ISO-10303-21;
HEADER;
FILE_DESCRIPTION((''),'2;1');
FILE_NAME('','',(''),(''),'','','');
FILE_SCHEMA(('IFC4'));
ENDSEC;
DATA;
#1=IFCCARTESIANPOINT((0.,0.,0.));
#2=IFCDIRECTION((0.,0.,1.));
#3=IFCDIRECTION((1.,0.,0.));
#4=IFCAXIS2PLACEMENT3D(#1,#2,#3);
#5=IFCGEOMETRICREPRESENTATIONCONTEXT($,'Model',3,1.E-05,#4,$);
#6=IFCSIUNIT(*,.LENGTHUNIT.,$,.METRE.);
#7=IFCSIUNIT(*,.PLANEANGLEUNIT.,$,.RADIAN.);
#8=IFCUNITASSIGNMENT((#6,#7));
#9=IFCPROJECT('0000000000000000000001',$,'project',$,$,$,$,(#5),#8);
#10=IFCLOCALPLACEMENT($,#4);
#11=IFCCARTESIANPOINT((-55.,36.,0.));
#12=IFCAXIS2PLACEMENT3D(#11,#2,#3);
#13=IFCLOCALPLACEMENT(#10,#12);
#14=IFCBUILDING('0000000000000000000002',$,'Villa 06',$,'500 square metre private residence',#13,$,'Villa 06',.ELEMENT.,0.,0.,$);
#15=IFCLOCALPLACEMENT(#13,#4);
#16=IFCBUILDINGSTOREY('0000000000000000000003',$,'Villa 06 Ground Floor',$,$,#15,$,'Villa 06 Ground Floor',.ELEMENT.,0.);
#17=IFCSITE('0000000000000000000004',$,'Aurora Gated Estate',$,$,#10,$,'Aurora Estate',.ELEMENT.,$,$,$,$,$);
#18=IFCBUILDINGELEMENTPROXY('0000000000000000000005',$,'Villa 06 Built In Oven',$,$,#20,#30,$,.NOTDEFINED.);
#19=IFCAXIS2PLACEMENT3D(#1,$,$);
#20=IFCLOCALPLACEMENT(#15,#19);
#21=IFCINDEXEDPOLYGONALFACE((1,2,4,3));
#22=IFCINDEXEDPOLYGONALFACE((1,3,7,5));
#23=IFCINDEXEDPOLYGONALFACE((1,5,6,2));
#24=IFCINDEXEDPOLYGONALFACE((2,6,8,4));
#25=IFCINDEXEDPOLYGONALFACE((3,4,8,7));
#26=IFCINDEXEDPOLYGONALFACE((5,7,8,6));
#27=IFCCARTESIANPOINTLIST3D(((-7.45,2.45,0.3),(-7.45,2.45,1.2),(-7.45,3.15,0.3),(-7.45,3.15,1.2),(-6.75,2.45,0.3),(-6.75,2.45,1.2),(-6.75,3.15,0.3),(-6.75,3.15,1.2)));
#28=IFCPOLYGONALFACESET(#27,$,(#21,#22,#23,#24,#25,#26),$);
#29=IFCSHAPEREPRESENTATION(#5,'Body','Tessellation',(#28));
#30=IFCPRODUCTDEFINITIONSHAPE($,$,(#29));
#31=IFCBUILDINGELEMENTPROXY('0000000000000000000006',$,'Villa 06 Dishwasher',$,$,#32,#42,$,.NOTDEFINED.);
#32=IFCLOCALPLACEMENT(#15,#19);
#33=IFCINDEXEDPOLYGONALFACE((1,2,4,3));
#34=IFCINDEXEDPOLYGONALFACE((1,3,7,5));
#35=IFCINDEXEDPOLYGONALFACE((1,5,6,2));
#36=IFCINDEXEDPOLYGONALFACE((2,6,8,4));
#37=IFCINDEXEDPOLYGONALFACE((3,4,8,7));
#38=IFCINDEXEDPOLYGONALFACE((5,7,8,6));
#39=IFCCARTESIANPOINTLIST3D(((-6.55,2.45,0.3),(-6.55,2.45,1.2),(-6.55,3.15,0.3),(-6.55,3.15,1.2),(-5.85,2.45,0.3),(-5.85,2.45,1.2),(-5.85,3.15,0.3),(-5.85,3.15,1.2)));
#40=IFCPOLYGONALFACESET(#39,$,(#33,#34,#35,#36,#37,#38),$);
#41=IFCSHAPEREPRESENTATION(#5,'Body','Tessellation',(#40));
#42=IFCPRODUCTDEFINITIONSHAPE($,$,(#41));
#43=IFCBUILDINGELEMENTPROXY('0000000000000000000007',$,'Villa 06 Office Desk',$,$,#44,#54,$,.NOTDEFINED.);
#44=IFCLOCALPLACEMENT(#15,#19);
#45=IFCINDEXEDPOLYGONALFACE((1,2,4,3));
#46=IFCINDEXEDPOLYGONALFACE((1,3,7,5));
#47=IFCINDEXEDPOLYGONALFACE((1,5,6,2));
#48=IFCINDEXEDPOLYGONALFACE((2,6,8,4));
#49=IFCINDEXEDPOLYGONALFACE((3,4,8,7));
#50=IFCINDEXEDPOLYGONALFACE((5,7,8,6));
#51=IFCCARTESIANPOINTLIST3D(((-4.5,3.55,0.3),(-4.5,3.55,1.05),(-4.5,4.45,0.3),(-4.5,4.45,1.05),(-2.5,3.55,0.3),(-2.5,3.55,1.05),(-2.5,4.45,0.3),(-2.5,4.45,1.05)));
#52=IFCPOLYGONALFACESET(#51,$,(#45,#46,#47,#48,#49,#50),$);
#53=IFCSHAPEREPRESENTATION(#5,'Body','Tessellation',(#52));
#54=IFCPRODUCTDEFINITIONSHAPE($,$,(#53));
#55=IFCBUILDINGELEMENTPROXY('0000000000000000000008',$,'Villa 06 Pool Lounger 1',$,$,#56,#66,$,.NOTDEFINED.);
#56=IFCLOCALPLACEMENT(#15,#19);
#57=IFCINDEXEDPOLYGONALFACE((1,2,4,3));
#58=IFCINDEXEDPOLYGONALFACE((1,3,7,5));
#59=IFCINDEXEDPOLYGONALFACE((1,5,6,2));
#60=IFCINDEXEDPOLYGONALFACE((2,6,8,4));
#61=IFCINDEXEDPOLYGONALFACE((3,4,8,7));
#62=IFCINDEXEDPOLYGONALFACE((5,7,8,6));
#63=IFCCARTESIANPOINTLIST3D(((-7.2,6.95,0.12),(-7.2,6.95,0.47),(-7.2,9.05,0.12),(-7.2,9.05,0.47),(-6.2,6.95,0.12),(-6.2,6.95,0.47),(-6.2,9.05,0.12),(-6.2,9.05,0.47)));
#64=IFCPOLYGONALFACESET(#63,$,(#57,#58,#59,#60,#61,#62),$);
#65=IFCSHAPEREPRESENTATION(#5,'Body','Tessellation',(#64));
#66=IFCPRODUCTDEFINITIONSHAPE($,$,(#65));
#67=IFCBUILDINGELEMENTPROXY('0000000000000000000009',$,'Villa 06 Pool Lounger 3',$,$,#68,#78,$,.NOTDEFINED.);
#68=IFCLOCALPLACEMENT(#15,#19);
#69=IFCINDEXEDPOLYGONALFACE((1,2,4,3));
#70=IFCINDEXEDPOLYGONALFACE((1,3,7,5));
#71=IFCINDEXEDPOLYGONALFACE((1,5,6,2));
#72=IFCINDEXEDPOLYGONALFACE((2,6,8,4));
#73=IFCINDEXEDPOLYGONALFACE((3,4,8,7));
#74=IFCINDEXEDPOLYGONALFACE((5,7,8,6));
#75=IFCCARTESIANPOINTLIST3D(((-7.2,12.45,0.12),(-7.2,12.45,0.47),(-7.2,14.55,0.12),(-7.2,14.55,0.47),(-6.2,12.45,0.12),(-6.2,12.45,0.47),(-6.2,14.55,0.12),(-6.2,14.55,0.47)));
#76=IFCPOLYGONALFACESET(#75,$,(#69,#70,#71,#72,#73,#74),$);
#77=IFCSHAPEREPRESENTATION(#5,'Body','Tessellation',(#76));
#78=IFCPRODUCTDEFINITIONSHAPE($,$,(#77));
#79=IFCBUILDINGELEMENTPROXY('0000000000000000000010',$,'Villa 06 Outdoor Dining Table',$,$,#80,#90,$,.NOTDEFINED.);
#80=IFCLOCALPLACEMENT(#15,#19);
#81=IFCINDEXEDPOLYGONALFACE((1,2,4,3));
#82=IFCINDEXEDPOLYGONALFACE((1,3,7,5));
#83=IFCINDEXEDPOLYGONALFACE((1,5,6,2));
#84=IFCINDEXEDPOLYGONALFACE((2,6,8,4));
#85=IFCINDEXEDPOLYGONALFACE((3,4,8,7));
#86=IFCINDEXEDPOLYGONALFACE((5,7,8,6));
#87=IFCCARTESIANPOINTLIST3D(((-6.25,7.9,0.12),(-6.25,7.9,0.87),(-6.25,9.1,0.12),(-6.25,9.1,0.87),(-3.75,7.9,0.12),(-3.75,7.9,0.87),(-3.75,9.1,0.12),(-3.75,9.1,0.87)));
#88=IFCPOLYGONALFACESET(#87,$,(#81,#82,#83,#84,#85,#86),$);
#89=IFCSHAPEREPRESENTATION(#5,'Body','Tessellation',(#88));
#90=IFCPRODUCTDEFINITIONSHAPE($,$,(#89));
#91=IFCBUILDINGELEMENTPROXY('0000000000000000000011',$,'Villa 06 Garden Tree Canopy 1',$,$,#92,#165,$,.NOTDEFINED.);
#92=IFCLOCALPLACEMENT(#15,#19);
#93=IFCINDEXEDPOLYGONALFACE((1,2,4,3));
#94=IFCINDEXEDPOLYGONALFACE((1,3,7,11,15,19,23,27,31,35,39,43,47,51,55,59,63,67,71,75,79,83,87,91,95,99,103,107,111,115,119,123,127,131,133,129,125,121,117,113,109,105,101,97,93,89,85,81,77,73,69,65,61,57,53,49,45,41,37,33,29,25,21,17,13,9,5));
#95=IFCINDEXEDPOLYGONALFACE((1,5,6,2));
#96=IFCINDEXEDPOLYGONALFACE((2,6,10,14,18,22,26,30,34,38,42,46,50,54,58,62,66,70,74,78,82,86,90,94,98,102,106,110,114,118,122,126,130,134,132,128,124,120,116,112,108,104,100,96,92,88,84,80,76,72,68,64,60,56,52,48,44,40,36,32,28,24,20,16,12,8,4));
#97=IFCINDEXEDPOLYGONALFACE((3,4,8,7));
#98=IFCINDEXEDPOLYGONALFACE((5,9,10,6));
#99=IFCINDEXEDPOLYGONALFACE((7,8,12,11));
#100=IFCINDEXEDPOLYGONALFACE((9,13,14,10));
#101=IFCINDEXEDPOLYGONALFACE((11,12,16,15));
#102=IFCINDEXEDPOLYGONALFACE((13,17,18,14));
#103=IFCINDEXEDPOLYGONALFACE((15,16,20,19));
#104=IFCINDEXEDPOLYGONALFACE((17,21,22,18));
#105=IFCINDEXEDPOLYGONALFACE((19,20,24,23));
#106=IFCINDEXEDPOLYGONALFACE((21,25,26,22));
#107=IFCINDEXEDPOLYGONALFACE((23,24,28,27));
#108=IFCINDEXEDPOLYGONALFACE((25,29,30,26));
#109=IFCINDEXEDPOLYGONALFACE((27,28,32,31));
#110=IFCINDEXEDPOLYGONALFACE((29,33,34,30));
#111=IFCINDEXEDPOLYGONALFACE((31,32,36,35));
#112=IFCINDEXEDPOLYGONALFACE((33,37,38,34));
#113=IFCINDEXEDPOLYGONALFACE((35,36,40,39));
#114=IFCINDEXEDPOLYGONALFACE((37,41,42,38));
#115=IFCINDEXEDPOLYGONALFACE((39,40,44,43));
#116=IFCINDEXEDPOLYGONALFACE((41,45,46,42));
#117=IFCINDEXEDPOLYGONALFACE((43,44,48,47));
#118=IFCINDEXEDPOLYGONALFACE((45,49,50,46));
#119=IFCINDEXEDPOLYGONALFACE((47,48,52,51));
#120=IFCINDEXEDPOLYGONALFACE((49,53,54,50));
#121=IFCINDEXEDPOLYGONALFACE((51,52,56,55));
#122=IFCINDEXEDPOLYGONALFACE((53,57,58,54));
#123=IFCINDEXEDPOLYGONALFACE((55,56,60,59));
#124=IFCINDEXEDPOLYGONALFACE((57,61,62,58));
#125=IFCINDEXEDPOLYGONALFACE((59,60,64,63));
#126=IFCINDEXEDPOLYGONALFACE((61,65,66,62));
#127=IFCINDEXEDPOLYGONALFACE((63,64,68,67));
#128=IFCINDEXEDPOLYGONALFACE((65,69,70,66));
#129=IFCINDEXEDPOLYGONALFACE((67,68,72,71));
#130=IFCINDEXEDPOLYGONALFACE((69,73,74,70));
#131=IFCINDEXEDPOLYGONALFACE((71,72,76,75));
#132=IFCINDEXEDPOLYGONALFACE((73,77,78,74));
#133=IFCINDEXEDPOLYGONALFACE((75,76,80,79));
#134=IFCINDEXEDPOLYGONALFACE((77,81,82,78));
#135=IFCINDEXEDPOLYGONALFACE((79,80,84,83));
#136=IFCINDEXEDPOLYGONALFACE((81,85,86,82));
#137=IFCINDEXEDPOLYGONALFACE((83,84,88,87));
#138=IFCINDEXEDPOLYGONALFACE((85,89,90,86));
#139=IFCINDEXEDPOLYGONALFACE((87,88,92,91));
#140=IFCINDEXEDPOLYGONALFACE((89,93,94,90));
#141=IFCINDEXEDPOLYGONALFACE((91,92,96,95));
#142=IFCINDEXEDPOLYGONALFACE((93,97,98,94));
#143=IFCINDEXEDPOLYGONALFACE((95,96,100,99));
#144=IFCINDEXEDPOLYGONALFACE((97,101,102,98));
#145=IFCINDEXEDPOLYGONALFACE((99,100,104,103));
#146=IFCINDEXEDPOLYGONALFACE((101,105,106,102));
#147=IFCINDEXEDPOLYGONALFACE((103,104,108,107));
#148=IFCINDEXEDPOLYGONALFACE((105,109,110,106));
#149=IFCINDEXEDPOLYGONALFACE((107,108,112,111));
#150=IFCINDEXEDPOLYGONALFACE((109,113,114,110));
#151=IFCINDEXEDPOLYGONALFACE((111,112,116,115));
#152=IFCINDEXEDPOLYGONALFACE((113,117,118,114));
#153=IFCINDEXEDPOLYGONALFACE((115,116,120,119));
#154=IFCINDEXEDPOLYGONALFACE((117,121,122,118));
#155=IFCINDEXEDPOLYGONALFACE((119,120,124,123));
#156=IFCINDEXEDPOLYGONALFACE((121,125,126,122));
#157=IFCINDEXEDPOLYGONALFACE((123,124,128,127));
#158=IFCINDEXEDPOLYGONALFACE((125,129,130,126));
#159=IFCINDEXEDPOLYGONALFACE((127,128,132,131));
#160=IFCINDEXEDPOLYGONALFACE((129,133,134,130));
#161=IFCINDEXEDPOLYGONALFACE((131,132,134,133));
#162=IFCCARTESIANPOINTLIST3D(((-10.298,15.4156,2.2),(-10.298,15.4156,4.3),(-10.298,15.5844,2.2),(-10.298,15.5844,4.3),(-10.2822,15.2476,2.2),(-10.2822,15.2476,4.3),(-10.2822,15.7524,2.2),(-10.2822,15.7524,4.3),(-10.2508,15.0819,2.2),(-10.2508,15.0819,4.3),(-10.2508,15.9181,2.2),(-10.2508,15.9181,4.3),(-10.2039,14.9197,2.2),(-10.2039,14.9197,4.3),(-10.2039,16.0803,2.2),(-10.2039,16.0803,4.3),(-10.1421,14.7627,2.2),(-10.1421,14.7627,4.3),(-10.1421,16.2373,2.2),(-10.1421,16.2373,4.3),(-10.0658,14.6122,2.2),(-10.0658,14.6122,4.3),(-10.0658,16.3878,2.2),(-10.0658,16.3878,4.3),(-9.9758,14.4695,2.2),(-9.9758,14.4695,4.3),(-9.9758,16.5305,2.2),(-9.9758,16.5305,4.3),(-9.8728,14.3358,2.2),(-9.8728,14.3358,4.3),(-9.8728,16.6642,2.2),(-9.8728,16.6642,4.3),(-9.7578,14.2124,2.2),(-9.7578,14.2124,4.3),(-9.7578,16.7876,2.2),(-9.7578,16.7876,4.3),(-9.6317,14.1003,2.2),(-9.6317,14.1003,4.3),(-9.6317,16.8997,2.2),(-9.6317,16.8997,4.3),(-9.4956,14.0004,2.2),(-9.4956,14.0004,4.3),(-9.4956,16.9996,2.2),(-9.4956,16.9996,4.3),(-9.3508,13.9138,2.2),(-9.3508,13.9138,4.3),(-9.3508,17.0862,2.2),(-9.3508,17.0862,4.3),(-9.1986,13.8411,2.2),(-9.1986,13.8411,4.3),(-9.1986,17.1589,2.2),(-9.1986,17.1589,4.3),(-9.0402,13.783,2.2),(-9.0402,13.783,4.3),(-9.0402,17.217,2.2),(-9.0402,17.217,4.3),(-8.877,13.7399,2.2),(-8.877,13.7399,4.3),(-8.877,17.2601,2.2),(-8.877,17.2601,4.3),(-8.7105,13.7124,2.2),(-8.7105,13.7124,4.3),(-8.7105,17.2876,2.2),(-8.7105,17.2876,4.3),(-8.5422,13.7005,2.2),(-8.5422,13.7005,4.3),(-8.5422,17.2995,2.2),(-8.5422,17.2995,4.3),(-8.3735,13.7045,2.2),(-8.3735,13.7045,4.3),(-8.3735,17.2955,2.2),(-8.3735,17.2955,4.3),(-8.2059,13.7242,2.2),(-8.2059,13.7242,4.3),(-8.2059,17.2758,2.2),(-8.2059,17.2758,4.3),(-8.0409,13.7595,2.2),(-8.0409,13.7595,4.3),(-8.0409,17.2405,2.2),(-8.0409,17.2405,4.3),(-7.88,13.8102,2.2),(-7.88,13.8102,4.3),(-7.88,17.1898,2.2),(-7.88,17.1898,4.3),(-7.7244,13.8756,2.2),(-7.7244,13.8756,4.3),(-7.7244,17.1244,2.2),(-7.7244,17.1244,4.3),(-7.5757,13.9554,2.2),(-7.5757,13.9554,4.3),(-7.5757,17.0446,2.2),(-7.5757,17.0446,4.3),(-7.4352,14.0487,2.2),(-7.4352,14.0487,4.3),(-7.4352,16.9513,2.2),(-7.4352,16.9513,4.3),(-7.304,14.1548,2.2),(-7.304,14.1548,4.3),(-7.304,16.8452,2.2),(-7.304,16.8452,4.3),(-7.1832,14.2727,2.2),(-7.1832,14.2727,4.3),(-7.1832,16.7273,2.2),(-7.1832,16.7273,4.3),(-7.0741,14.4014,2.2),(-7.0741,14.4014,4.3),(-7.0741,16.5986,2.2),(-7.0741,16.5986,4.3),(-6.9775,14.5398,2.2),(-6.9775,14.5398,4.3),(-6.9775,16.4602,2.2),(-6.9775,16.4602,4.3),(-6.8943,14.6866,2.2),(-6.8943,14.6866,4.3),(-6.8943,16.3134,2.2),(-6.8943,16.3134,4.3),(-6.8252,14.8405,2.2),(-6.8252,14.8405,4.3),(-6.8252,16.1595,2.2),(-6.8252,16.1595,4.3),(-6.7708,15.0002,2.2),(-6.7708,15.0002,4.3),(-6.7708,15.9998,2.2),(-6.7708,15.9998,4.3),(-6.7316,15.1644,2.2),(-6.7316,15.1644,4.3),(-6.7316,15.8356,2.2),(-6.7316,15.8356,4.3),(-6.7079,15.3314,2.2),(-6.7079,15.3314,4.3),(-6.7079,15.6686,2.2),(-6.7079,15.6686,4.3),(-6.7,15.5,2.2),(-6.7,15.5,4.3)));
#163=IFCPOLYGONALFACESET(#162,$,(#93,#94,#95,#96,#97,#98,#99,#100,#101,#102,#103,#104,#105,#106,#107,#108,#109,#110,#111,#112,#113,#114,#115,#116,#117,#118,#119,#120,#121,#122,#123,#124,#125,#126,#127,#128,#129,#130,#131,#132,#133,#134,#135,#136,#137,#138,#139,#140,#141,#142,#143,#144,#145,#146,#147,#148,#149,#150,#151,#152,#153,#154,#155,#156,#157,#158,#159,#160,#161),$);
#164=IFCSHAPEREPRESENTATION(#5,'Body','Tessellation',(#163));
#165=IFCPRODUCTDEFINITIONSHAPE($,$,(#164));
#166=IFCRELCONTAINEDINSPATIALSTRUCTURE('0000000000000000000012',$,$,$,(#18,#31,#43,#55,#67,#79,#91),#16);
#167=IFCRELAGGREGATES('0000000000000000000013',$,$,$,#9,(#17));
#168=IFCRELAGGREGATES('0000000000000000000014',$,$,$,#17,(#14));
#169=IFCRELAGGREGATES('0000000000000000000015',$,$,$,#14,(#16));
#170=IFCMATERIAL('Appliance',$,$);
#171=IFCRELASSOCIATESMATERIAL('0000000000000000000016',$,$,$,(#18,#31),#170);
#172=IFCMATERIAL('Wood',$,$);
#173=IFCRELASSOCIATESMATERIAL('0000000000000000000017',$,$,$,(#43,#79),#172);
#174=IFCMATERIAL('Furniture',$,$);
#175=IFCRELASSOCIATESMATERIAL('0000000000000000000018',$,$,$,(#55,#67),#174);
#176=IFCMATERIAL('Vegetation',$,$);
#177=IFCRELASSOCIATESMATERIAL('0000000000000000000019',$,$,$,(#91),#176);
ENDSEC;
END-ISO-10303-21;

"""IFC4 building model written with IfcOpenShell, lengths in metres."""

from ifc_helpers import new_model, si_unit, frame, origin_with_axes, origin_2d_with_axis, place, context, project, spatial, rectangle, circle, extrude, material, element, save


model = new_model("IFC4")

# Units and contexts
model_context = context("Model", 3, precision=1e-05, world=origin_with_axes())
ifc_project = project(units=[si_unit("LENGTHUNIT", "METRE"), si_unit("PLANEANGLEUNIT", "RADIAN")], contexts=[model_context])

# Site, building, storey
site_placement = place(None, origin_with_axes())
site = spatial("IfcSite", under=ifc_project, at=site_placement, Name="Aurora Gated Estate", LongName="Aurora Estate", CompositionType="ELEMENT")
building_placement = place(site_placement, frame((-55.0, 36.0, 0.0), z_axis=(0.0, 0.0, 1.0), x_axis=(1.0, 0.0, 0.0)))
building = spatial("IfcBuilding", under=site, at=building_placement, Name="Villa 06", ObjectType="500 square metre private residence", LongName="Villa 06", CompositionType="ELEMENT", ElevationOfRefHeight=0.0, ElevationOfTerrain=0.0)
storey_placement = place(building_placement, origin_with_axes())
storey = spatial("IfcBuildingStorey", under=building, at=storey_placement, Name="Villa 06 Ground Floor", LongName="Villa 06 Ground Floor", CompositionType="ELEMENT", Elevation=0.0)

# Shared definitions
ifc_material_1 = material(Name="Wood")

# Building element proxies
ifc_material_2 = material(Name="Appliance")
for number, where, z_axis, x_axis, name in (
    (1, (-7.1, 2.8, 0.3), (0.0, 0.0, 1.0), (1.0, 0.0, 0.0), "Villa 06 Built In Oven"),
    (2, (-6.2, 2.8, 0.3), (0.0, 0.0, 1.0), (1.0, 0.0, 0.0), "Villa 06 Dishwasher"),
):
    element("IfcBuildingElementProxy", number, at=place(storey_placement, frame(where, z_axis=z_axis, x_axis=x_axis)), inside=storey, material=ifc_material_2, Name=name, PredefinedType="NOTDEFINED", context=model_context, shape_type="SweptSolid", body=[
        extrude(rectangle(XDim=0.7, YDim=0.7, at=origin_2d_with_axis()), origin_with_axes(), (0.0, 0.0, 1.0), 0.9),
    ])
proxy_1_placement = place(storey_placement, frame((-3.5, 4.0, 0.3), z_axis=(0.0, 0.0, 1.0), x_axis=(1.0, 0.0, 0.0)))
element("IfcBuildingElementProxy", 3, at=proxy_1_placement, inside=storey, material=ifc_material_1, Name="Villa 06 Office Desk", PredefinedType="NOTDEFINED", context=model_context, shape_type="SweptSolid", body=[
    extrude(rectangle(XDim=2.0, YDim=0.9, at=origin_2d_with_axis()), origin_with_axes(), (0.0, 0.0, 1.0), 0.75),
])
ifc_material_3 = material(Name="Furniture")
for number, where, z_axis, x_axis, name in (
    (4, (-6.7, 8.0, 0.12), (0.0, 0.0, 1.0), (1.0, 0.0, 0.0), "Villa 06 Pool Lounger 1"),
    (5, (-6.7, 13.5, 0.12), (0.0, 0.0, 1.0), (1.0, 0.0, 0.0), "Villa 06 Pool Lounger 3"),
):
    element("IfcBuildingElementProxy", number, at=place(storey_placement, frame(where, z_axis=z_axis, x_axis=x_axis)), inside=storey, material=ifc_material_3, Name=name, PredefinedType="NOTDEFINED", context=model_context, shape_type="SweptSolid", body=[
        extrude(rectangle(XDim=1.0, YDim=2.1, at=origin_2d_with_axis()), origin_with_axes(), (0.0, 0.0, 1.0), 0.35),
    ])
proxy_2_placement = place(storey_placement, frame((-5.0, 8.5, 0.12), z_axis=(0.0, 0.0, 1.0), x_axis=(1.0, 0.0, 0.0)))
element("IfcBuildingElementProxy", 6, at=proxy_2_placement, inside=storey, material=ifc_material_1, Name="Villa 06 Outdoor Dining Table", PredefinedType="NOTDEFINED", context=model_context, shape_type="SweptSolid", body=[
    extrude(rectangle(XDim=2.5, YDim=1.2, at=origin_2d_with_axis()), origin_with_axes(), (0.0, 0.0, 1.0), 0.75),
])
ifc_material_4 = material(Name="Vegetation")
proxy_3_placement = place(storey_placement, frame((-8.5, 15.5, 2.2), z_axis=(0.0, 0.0, 1.0), x_axis=(1.0, 0.0, 0.0)))
element("IfcBuildingElementProxy", 7, at=proxy_3_placement, inside=storey, material=ifc_material_4, Name="Villa 06 Garden Tree Canopy 1", PredefinedType="NOTDEFINED", context=model_context, shape_type="SweptSolid", body=[
    extrude(circle(Radius=1.8, at=origin_2d_with_axis()), origin_with_axes(), (0.0, 0.0, 1.0), 2.1),
])

save(model, "model.ifc")
